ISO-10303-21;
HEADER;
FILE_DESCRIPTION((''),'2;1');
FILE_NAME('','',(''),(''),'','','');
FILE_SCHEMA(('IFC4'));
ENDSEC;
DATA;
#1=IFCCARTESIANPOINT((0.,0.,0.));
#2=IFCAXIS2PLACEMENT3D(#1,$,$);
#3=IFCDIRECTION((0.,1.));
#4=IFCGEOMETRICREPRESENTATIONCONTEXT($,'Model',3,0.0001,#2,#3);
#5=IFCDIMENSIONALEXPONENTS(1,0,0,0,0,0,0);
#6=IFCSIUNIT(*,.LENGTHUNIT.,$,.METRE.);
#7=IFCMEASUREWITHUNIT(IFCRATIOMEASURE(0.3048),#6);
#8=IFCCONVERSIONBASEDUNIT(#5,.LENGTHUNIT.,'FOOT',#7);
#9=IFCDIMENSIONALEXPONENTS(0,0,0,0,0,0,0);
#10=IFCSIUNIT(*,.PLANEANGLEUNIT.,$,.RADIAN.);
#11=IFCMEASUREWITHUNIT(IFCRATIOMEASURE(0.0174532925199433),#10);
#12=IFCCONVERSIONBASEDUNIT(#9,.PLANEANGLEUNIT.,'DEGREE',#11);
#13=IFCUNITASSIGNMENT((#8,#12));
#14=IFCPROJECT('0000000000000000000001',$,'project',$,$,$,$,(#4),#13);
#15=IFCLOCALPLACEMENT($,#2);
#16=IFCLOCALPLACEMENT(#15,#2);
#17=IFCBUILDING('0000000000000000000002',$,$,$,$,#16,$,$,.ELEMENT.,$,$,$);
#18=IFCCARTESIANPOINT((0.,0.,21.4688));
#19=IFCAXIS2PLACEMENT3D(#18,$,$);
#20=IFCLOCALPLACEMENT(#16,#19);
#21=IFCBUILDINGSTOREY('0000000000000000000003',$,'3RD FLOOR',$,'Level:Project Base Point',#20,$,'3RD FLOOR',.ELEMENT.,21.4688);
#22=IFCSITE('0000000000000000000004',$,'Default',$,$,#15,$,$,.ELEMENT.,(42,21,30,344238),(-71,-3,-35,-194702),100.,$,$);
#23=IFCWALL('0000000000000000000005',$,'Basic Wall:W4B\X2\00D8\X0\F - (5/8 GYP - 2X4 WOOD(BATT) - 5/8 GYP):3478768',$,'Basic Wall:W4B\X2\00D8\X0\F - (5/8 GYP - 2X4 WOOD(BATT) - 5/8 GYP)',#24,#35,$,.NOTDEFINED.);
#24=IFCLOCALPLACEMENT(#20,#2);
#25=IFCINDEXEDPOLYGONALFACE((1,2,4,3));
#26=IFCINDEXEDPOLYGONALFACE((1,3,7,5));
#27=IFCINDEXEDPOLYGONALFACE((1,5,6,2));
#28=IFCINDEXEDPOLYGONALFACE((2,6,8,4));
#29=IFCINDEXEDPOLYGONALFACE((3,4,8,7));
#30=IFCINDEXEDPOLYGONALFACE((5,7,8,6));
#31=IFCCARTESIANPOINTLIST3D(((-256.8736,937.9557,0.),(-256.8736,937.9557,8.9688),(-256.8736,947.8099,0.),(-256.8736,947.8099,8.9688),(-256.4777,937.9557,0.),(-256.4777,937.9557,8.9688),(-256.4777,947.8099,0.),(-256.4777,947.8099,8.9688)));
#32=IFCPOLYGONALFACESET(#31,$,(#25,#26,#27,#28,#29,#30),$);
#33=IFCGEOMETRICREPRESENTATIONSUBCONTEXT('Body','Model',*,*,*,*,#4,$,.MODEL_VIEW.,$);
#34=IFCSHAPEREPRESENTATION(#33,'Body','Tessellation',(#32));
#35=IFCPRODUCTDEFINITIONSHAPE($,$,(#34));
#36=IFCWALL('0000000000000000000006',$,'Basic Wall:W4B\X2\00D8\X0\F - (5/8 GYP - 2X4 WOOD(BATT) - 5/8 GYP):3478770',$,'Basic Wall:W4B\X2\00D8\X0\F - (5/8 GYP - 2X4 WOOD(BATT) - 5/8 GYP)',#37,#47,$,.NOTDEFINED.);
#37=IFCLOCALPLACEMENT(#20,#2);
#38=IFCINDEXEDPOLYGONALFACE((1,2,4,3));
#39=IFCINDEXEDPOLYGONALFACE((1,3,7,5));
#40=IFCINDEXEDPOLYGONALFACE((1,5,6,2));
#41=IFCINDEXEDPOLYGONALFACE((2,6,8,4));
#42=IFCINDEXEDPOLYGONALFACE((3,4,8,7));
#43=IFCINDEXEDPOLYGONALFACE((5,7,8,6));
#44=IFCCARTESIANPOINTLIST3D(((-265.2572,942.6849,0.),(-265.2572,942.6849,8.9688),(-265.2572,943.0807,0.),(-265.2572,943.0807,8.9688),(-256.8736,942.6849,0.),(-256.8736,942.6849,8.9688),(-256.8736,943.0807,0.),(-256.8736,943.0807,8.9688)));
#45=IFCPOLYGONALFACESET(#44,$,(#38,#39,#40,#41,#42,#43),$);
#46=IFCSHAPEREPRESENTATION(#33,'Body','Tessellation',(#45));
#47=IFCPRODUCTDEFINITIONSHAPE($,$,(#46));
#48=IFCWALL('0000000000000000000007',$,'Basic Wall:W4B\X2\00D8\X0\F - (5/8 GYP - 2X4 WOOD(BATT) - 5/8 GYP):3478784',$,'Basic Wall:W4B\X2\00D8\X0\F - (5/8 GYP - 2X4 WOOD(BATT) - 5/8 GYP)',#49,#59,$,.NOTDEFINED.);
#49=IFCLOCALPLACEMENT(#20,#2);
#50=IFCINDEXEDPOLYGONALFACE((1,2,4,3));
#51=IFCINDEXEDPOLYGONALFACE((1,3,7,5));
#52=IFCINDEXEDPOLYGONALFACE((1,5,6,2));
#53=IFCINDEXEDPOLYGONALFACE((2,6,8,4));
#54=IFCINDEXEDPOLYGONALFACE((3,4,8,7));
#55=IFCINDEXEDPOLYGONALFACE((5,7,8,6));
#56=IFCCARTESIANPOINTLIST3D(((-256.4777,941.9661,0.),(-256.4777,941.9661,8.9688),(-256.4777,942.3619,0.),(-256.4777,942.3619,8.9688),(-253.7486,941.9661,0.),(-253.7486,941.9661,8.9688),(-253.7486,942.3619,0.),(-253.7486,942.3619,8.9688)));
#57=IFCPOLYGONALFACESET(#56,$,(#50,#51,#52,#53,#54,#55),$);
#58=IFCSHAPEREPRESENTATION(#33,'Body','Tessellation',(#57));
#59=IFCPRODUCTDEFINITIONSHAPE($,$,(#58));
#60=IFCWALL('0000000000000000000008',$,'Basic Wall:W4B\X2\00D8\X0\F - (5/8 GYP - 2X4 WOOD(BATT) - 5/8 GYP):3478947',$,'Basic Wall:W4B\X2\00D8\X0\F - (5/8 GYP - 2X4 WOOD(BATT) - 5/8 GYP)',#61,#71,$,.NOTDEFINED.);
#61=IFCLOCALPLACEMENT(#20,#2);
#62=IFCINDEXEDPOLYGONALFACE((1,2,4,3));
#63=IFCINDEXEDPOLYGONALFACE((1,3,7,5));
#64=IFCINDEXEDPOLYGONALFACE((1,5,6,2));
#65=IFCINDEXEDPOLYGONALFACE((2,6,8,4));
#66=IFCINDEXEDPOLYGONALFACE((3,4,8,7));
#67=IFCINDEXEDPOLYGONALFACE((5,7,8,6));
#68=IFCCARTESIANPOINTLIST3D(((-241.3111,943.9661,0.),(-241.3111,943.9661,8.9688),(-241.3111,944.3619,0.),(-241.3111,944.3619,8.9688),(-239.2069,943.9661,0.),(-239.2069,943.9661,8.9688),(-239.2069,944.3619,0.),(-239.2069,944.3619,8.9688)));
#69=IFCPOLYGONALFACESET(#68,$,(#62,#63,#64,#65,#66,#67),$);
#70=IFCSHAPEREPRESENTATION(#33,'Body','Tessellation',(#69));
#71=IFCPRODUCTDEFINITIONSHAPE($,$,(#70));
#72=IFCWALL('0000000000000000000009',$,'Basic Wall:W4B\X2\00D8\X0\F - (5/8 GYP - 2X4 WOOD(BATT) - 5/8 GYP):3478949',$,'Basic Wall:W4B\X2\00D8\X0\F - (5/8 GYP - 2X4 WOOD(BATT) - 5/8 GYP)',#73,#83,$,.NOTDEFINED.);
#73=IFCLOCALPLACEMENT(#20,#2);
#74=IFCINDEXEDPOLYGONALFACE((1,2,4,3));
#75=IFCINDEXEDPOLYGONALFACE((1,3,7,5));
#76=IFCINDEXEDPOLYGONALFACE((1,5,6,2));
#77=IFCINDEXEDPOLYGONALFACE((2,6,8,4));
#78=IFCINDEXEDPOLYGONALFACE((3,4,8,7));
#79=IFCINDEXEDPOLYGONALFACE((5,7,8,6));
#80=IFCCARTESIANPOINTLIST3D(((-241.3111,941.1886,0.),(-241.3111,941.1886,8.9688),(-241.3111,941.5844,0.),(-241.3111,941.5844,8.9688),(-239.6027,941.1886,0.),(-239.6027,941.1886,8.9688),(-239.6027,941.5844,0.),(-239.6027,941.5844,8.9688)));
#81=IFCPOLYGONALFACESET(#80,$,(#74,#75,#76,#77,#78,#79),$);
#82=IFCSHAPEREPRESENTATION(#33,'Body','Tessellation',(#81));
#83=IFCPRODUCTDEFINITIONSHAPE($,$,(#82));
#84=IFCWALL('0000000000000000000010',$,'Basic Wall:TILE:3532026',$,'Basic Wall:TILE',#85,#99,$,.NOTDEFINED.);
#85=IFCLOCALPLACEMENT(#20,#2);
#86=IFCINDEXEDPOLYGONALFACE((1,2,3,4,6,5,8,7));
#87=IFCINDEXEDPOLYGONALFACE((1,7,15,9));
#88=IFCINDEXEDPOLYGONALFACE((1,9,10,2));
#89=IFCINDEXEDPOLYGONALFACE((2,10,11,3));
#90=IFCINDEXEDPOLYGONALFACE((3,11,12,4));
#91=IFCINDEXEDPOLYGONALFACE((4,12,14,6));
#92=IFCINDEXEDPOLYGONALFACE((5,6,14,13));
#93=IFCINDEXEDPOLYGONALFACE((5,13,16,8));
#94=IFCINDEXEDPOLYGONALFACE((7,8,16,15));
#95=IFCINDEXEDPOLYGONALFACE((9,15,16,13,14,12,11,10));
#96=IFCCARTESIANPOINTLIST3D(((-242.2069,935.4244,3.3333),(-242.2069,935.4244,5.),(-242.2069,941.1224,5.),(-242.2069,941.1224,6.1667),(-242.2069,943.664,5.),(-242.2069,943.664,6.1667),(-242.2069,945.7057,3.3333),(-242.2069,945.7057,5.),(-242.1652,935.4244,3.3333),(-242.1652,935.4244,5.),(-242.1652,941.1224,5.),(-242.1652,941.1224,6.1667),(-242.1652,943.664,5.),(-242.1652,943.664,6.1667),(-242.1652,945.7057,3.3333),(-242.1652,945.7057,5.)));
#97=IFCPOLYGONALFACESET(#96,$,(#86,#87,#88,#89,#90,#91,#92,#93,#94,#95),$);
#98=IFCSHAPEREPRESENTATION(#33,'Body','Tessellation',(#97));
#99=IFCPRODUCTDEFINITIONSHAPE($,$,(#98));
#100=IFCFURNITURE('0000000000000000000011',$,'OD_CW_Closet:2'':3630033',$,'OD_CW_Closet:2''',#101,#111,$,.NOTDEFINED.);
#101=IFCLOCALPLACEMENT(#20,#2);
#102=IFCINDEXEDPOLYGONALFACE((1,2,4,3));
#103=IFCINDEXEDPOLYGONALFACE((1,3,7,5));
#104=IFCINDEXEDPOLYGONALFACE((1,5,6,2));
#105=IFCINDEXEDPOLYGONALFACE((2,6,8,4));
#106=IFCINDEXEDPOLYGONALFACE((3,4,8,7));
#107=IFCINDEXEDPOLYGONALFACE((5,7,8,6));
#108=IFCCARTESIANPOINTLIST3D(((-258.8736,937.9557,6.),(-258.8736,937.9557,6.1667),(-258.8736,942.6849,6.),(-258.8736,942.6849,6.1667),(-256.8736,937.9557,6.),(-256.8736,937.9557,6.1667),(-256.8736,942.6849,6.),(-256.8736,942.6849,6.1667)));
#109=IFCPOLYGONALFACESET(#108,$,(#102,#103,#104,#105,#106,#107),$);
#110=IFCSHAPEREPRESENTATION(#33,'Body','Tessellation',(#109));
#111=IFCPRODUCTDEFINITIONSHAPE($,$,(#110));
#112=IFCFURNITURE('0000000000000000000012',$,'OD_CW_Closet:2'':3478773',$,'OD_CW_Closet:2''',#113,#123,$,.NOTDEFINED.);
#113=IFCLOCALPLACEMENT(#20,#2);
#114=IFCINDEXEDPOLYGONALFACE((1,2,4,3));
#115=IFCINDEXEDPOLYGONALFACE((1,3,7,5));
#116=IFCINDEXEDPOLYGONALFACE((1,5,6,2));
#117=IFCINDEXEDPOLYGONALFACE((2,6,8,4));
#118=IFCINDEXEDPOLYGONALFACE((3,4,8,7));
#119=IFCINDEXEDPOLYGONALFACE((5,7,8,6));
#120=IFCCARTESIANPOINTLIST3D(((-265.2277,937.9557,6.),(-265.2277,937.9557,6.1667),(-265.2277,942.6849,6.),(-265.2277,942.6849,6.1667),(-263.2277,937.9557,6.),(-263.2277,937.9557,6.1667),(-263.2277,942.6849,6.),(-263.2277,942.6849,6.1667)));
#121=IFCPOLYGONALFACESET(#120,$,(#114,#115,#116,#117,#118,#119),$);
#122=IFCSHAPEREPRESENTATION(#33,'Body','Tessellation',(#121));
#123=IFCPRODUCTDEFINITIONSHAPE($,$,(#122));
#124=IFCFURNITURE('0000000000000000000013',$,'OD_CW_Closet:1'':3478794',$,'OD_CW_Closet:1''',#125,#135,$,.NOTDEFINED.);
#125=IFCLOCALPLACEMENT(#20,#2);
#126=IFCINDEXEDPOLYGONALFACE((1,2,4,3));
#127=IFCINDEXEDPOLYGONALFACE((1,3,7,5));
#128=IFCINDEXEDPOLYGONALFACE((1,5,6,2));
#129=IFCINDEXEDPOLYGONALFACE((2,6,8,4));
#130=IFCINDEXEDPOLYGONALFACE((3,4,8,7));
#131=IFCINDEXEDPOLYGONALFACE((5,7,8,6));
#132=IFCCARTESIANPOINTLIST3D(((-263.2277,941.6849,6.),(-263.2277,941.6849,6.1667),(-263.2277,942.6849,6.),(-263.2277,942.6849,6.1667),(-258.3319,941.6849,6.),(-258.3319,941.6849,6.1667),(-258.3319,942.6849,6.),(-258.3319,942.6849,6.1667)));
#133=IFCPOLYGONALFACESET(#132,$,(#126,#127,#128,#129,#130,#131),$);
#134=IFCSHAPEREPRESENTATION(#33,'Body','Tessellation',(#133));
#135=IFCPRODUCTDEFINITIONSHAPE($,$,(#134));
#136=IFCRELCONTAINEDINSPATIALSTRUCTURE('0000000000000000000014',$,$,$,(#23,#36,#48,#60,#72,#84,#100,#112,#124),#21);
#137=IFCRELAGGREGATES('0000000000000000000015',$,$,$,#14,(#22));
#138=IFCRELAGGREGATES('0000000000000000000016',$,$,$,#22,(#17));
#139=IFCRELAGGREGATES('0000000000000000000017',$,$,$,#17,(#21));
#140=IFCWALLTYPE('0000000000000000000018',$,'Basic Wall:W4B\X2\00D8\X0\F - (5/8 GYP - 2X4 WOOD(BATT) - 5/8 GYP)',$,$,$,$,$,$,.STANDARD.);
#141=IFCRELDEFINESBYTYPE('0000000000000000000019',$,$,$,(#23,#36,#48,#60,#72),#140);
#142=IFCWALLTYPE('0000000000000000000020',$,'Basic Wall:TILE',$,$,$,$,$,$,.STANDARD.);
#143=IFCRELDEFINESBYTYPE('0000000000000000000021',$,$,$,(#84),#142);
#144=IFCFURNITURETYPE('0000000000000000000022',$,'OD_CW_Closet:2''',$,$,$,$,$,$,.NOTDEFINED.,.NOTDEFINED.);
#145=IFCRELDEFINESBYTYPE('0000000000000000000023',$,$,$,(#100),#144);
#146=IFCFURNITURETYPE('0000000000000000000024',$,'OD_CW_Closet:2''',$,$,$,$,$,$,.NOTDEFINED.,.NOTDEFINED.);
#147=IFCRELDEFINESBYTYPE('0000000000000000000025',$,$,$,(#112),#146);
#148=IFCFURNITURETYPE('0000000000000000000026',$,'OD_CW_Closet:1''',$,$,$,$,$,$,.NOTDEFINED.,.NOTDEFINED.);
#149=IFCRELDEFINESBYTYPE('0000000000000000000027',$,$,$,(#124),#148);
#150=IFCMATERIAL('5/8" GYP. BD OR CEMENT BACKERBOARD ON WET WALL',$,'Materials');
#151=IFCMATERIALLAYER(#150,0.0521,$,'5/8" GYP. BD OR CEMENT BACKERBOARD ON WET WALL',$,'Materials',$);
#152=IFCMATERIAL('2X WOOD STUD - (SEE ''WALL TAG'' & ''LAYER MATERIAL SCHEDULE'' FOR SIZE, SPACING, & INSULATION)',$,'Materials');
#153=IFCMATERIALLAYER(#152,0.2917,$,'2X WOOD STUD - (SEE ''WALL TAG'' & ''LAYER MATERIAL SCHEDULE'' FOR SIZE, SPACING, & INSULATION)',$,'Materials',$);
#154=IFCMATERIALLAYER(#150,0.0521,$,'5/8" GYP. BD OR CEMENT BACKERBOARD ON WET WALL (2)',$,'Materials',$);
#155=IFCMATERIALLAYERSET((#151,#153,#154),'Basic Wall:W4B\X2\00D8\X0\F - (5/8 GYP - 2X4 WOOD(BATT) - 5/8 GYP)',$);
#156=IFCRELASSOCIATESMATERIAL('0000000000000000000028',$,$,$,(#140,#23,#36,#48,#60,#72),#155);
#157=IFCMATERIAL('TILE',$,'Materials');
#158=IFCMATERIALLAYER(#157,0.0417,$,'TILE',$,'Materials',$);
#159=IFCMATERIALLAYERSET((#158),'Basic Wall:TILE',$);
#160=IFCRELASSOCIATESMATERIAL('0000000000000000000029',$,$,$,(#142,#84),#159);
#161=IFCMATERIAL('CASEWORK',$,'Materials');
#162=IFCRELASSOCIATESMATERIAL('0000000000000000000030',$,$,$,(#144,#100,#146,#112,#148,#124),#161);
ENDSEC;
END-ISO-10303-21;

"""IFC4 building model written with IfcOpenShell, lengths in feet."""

from ifc_helpers import new_model, entity, si_unit, converted_unit, direction, frame, frame_2d, origin, origin_2d_with_axis, place, context, subcontext, project, spatial, rectangle, extrude, source, transform, mapped, material, layer, layer_set, layer_usage, type_object, type_shapes, element, save


model = new_model("IFC4")

# Units and contexts
model_context = context("Model", 3, precision=0.0001, world=origin(), true_north=direction((0.0, 1.0)))
body_context = subcontext(model_context, "Body", "Model", "MODEL_VIEW")
ifc_project = project(units=[converted_unit("LENGTHUNIT", "FOOT", entity("IfcRatioMeasure", 0.3048), si_unit("LENGTHUNIT", "METRE"), dimensions=[1, 0, 0, 0, 0, 0, 0]), converted_unit("PLANEANGLEUNIT", "DEGREE", entity("IfcRatioMeasure", 0.0174532925199433), si_unit("PLANEANGLEUNIT", "RADIAN"), dimensions=[0, 0, 0, 0, 0, 0, 0])], contexts=[model_context])

# Site, building, storey
site_placement = place(None, origin())
site = spatial("IfcSite", under=ifc_project, at=site_placement, Name="Default", CompositionType="ELEMENT", RefLatitude=(42, 21, 30, 344238), RefLongitude=(-71, -3, -35, -194702), RefElevation=100.0)
building_placement = place(site_placement, origin())
building = spatial("IfcBuilding", under=site, at=building_placement, CompositionType="ELEMENT")
storey_placement = place(building_placement, frame((0.0, 0.0, 21.4688)))
storey = spatial("IfcBuildingStorey", under=building, at=storey_placement, Name="3RD FLOOR", ObjectType="Level:Project Base Point", LongName="3RD FLOOR", CompositionType="ELEMENT", Elevation=21.4688)

# Shared definitions
ifc_material_1 = material(Name="5/8\" GYP. BD OR CEMENT BACKERBOARD ON WET WALL", Category="Materials")
ifc_layer_1 = layer(ifc_material_1, 0.0521, Name="5/8\" GYP. BD OR CEMENT BACKERBOARD ON WET WALL", Category="Materials")
ifc_material_2 = material(Name="2X WOOD STUD - (SEE 'WALL TAG' & 'LAYER MATERIAL SCHEDULE' FOR SIZE, SPACING, & INSULATION)", Category="Materials")
ifc_layer_2 = layer(ifc_material_2, 0.2917, Name="2X WOOD STUD - (SEE 'WALL TAG' & 'LAYER MATERIAL SCHEDULE' FOR SIZE, SPACING, & INSULATION)", Category="Materials")
ifc_layer_3 = layer(ifc_material_1, 0.0521, Name="5/8\" GYP. BD OR CEMENT BACKERBOARD ON WET WALL (2)", Category="Materials")
ifc_layer_set_1 = layer_set([ifc_layer_1, ifc_layer_2, ifc_layer_3], Name="Basic Wall:W4BØF - (5/8 GYP - 2X4 WOOD(BATT) - 5/8 GYP)")
wall_type_1 = type_object("IfcWallType", Name="Basic Wall:W4BØF - (5/8 GYP - 2X4 WOOD(BATT) - 5/8 GYP)", PredefinedType="STANDARD", material=ifc_layer_set_1)

# Walls
ifc_layer_usage_1 = layer_usage(ifc_layer_set_1, "AXIS2", "NEGATIVE", 0.1979)
wall_1_placement = place(storey_placement, frame((-256.6757, 937.9557, 0.0), z_axis=(0.0, 0.0, 1.0), x_axis=(0.0, 1.0, 0.0)))
element("IfcWall", 1, at=wall_1_placement, inside=storey, type_object=wall_type_1, material=ifc_layer_usage_1, Name="Basic Wall:W4BØF - (5/8 GYP - 2X4 WOOD(BATT) - 5/8 GYP):3478768", ObjectType="Basic Wall:W4BØF - (5/8 GYP - 2X4 WOOD(BATT) - 5/8 GYP)", PredefinedType="NOTDEFINED", context=body_context, shape_type="SweptSolid", body=[
    extrude(rectangle(XDim=9.8542, YDim=0.3958, at=frame_2d((4.9271, 0.0), x_axis=(-1.0, 0.0))), origin(), (0.0, 0.0, 1.0), 8.9688),
])
ifc_layer_usage_2 = layer_usage(ifc_layer_set_1, "AXIS2", "POSITIVE", -0.1979)
wall_2_placement = place(storey_placement, frame((-256.8736, 942.8828, 0.0), z_axis=(0.0, 0.0, 1.0), x_axis=(-1.0, 0.0, 0.0)))
element("IfcWall", 2, at=wall_2_placement, inside=storey, type_object=wall_type_1, material=ifc_layer_usage_2, Name="Basic Wall:W4BØF - (5/8 GYP - 2X4 WOOD(BATT) - 5/8 GYP):3478770", ObjectType="Basic Wall:W4BØF - (5/8 GYP - 2X4 WOOD(BATT) - 5/8 GYP)", PredefinedType="NOTDEFINED", context=body_context, shape_type="SweptSolid", body=[
    extrude(rectangle(XDim=8.3836, YDim=0.3958, at=frame_2d((4.1918, 0.0), x_axis=(-1.0, 0.0))), origin(), (0.0, 0.0, 1.0), 8.9688),
])
ifc_layer_usage_3 = layer_usage(ifc_layer_set_1, "AXIS2", "NEGATIVE", 0.1979)
wall_3_placement = place(storey_placement, frame((-256.4777, 942.164, 0.0)))
element("IfcWall", 3, at=wall_3_placement, inside=storey, type_object=wall_type_1, material=ifc_layer_usage_3, Name="Basic Wall:W4BØF - (5/8 GYP - 2X4 WOOD(BATT) - 5/8 GYP):3478784", ObjectType="Basic Wall:W4BØF - (5/8 GYP - 2X4 WOOD(BATT) - 5/8 GYP)", PredefinedType="NOTDEFINED", context=body_context, shape_type="SweptSolid", body=[
    extrude(rectangle(XDim=2.7292, YDim=0.3958, at=frame_2d((1.3646, 0.0), x_axis=(-1.0, 0.0))), origin(), (0.0, 0.0, 1.0), 8.9688),
])
ifc_layer_usage_4 = layer_usage(ifc_layer_set_1, "AXIS2", "NEGATIVE", 0.1979)
wall_4_placement = place(storey_placement, frame((-241.3111, 944.164, 0.0)))
element("IfcWall", 4, at=wall_4_placement, inside=storey, type_object=wall_type_1, material=ifc_layer_usage_4, Name="Basic Wall:W4BØF - (5/8 GYP - 2X4 WOOD(BATT) - 5/8 GYP):3478947", ObjectType="Basic Wall:W4BØF - (5/8 GYP - 2X4 WOOD(BATT) - 5/8 GYP)", PredefinedType="NOTDEFINED", context=body_context, shape_type="SweptSolid", body=[
    extrude(rectangle(XDim=2.1042, YDim=0.3958, at=frame_2d((1.0521, 0.0), x_axis=(-1.0, 0.0))), origin(), (0.0, 0.0, 1.0), 8.9688),
])

# Wall
ifc_layer_usage_5 = layer_usage(ifc_layer_set_1, "AXIS2", "NEGATIVE", 0.1979)
wall_5_placement = place(storey_placement, frame((-239.6027, 941.3865, 0.0), z_axis=(0.0, 0.0, 1.0), x_axis=(-1.0, 0.0, 0.0)))
element("IfcWall", 5, at=wall_5_placement, inside=storey, type_object=wall_type_1, material=ifc_layer_usage_5, Name="Basic Wall:W4BØF - (5/8 GYP - 2X4 WOOD(BATT) - 5/8 GYP):3478949", ObjectType="Basic Wall:W4BØF - (5/8 GYP - 2X4 WOOD(BATT) - 5/8 GYP)", PredefinedType="NOTDEFINED", context=body_context, shape_type="SweptSolid", body=[
    extrude(rectangle(XDim=1.7083, YDim=0.3958, at=frame_2d((0.8542, 0.0), x_axis=(-1.0, 0.0))), origin(), (0.0, 0.0, 1.0), 8.9688),
])

# Wall, openings
ifc_material_3 = material(Name="TILE", Category="Materials")
ifc_layer_4 = layer(ifc_material_3, 0.0417, Name="TILE", Category="Materials")
ifc_layer_set_2 = layer_set([ifc_layer_4], Name="Basic Wall:TILE")
ifc_layer_usage_6 = layer_usage(ifc_layer_set_2, "AXIS2", "NEGATIVE", 0.0208)
wall_type_2 = type_object("IfcWallType", Name="Basic Wall:TILE", PredefinedType="STANDARD", material=ifc_layer_set_2)
wall_6_placement = place(storey_placement, frame((-242.1861, 945.7057, 3.3333), z_axis=(0.0, 0.0, 1.0), x_axis=(0.0, -1.0, 0.0)))
wall_6 = element("IfcWall", 6, at=wall_6_placement, inside=storey, type_object=wall_type_2, material=ifc_layer_usage_6, Name="Basic Wall:TILE:3532026", ObjectType="Basic Wall:TILE", PredefinedType="NOTDEFINED", context=body_context, shape_type="SweptSolid", body=[
    extrude(rectangle(XDim=10.2813, YDim=0.0417, at=frame_2d((5.1406, 0.0), x_axis=(-1.0, 0.0))), origin(), (0.0, 0.0, 1.0), 2.8333),
])
opening_1_placement = place(wall_6_placement, origin())
element("IfcOpeningElement", 7, at=opening_1_placement, cuts=wall_6, PredefinedType="OPENING", context=body_context, shape_type="SweptSolid", body=[
    extrude(rectangle(XDim=1.1667, YDim=5.6979, at=origin_2d_with_axis()), frame((7.4323, 0.0208, 2.25), z_axis=(0.0, -1.0, 0.0), x_axis=(0.0, 0.0, 1.0)), (0.0, 0.0, 1.0), 0.0417),
])
opening_2_placement = place(wall_6_placement, origin())
element("IfcOpeningElement", 8, at=opening_2_placement, cuts=wall_6, PredefinedType="OPENING", context=body_context, shape_type="SweptSolid", body=[
    extrude(rectangle(XDim=1.1667, YDim=2.0417, at=frame_2d((0.0, 0.0), x_axis=(0.0, 1.0))), frame((1.0208, 0.0208, 2.25), z_axis=(0.0, -1.0, 0.0), x_axis=(-1.0, 0.0, 0.0)), (0.0, 0.0, 1.0), 0.0417),
])

# Furniture
ifc_material_4 = material(Name="CASEWORK", Category="Materials")
furniture_type_1 = type_object("IfcFurnitureType", Name="OD_CW_Closet:2'", AssemblyPlace="NOTDEFINED", PredefinedType="NOTDEFINED", material=ifc_material_4)
shared_shape_1 = source(origin(), body_context, "Body", "SweptSolid", [
    extrude(rectangle(XDim=4.7292, YDim=2.0, at=origin_2d_with_axis()), frame((2.3646, 1.0, 0.0)), (0.0, 0.0, 1.0), 0.1667),
])
type_shapes(furniture_type_1, [shared_shape_1])
furniture_1_placement = place(storey_placement, frame((-256.8736, 937.9557, 6.0), z_axis=(0.0, 0.0, 1.0), x_axis=(0.0, 1.0, 0.0)))
element("IfcFurniture", 9, at=furniture_1_placement, inside=storey, type_object=furniture_type_1, material=ifc_material_4, Name="OD_CW_Closet:2':3630033", ObjectType="OD_CW_Closet:2'", PredefinedType="NOTDEFINED", context=body_context, shape_type="MappedRepresentation", body=[
    mapped(shared_shape_1, transform((0.0, 0.0, 0.0), scale=1.0)),
])
furniture_type_2 = type_object("IfcFurnitureType", Name="OD_CW_Closet:2'", AssemblyPlace="NOTDEFINED", PredefinedType="NOTDEFINED", material=ifc_material_4)
shared_shape_2 = source(origin(), body_context, "Body", "SweptSolid", [
    extrude(rectangle(XDim=2.0, YDim=4.7292, at=origin_2d_with_axis()), frame((2.3646, 1.0, 0.0), z_axis=(0.0, 0.0, 1.0), x_axis=(0.0, -1.0, 0.0)), (0.0, 0.0, 1.0), 0.1667),
])
type_shapes(furniture_type_2, [shared_shape_2])
furniture_2_placement = place(storey_placement, frame((-263.2277, 937.9557, 6.0), z_axis=(0.0, 0.0, 1.0), x_axis=(0.0, 1.0, 0.0)))
element("IfcFurniture", 10, at=furniture_2_placement, inside=storey, type_object=furniture_type_2, material=ifc_material_4, Name="OD_CW_Closet:2':3478773", ObjectType="OD_CW_Closet:2'", PredefinedType="NOTDEFINED", context=body_context, shape_type="MappedRepresentation", body=[
    mapped(shared_shape_2, transform((0.0, 0.0, 0.0), scale=1.0)),
])
furniture_type_3 = type_object("IfcFurnitureType", Name="OD_CW_Closet:1'", AssemblyPlace="NOTDEFINED", PredefinedType="NOTDEFINED", material=ifc_material_4)
shared_shape_3 = source(origin(), body_context, "Body", "SweptSolid", [
    extrude(rectangle(XDim=1.0, YDim=4.8958, at=frame_2d((0.0, 0.0), x_axis=(1.0, 0.0))), frame((2.4479, 0.5, 0.0), z_axis=(0.0, 0.0, 1.0), x_axis=(0.0, -1.0, 0.0)), (0.0, 0.0, 1.0), 0.1667),
])
type_shapes(furniture_type_3, [shared_shape_3])
furniture_3_placement = place(storey_placement, frame((-263.2277, 941.6849, 6.0)))
element("IfcFurniture", 11, at=furniture_3_placement, inside=storey, type_object=furniture_type_3, material=ifc_material_4, Name="OD_CW_Closet:1':3478794", ObjectType="OD_CW_Closet:1'", PredefinedType="NOTDEFINED", context=body_context, shape_type="MappedRepresentation", body=[
    mapped(shared_shape_3, transform((0.0, 0.0, 0.0), scale=1.0)),
])

save(model, "model.ifc")
